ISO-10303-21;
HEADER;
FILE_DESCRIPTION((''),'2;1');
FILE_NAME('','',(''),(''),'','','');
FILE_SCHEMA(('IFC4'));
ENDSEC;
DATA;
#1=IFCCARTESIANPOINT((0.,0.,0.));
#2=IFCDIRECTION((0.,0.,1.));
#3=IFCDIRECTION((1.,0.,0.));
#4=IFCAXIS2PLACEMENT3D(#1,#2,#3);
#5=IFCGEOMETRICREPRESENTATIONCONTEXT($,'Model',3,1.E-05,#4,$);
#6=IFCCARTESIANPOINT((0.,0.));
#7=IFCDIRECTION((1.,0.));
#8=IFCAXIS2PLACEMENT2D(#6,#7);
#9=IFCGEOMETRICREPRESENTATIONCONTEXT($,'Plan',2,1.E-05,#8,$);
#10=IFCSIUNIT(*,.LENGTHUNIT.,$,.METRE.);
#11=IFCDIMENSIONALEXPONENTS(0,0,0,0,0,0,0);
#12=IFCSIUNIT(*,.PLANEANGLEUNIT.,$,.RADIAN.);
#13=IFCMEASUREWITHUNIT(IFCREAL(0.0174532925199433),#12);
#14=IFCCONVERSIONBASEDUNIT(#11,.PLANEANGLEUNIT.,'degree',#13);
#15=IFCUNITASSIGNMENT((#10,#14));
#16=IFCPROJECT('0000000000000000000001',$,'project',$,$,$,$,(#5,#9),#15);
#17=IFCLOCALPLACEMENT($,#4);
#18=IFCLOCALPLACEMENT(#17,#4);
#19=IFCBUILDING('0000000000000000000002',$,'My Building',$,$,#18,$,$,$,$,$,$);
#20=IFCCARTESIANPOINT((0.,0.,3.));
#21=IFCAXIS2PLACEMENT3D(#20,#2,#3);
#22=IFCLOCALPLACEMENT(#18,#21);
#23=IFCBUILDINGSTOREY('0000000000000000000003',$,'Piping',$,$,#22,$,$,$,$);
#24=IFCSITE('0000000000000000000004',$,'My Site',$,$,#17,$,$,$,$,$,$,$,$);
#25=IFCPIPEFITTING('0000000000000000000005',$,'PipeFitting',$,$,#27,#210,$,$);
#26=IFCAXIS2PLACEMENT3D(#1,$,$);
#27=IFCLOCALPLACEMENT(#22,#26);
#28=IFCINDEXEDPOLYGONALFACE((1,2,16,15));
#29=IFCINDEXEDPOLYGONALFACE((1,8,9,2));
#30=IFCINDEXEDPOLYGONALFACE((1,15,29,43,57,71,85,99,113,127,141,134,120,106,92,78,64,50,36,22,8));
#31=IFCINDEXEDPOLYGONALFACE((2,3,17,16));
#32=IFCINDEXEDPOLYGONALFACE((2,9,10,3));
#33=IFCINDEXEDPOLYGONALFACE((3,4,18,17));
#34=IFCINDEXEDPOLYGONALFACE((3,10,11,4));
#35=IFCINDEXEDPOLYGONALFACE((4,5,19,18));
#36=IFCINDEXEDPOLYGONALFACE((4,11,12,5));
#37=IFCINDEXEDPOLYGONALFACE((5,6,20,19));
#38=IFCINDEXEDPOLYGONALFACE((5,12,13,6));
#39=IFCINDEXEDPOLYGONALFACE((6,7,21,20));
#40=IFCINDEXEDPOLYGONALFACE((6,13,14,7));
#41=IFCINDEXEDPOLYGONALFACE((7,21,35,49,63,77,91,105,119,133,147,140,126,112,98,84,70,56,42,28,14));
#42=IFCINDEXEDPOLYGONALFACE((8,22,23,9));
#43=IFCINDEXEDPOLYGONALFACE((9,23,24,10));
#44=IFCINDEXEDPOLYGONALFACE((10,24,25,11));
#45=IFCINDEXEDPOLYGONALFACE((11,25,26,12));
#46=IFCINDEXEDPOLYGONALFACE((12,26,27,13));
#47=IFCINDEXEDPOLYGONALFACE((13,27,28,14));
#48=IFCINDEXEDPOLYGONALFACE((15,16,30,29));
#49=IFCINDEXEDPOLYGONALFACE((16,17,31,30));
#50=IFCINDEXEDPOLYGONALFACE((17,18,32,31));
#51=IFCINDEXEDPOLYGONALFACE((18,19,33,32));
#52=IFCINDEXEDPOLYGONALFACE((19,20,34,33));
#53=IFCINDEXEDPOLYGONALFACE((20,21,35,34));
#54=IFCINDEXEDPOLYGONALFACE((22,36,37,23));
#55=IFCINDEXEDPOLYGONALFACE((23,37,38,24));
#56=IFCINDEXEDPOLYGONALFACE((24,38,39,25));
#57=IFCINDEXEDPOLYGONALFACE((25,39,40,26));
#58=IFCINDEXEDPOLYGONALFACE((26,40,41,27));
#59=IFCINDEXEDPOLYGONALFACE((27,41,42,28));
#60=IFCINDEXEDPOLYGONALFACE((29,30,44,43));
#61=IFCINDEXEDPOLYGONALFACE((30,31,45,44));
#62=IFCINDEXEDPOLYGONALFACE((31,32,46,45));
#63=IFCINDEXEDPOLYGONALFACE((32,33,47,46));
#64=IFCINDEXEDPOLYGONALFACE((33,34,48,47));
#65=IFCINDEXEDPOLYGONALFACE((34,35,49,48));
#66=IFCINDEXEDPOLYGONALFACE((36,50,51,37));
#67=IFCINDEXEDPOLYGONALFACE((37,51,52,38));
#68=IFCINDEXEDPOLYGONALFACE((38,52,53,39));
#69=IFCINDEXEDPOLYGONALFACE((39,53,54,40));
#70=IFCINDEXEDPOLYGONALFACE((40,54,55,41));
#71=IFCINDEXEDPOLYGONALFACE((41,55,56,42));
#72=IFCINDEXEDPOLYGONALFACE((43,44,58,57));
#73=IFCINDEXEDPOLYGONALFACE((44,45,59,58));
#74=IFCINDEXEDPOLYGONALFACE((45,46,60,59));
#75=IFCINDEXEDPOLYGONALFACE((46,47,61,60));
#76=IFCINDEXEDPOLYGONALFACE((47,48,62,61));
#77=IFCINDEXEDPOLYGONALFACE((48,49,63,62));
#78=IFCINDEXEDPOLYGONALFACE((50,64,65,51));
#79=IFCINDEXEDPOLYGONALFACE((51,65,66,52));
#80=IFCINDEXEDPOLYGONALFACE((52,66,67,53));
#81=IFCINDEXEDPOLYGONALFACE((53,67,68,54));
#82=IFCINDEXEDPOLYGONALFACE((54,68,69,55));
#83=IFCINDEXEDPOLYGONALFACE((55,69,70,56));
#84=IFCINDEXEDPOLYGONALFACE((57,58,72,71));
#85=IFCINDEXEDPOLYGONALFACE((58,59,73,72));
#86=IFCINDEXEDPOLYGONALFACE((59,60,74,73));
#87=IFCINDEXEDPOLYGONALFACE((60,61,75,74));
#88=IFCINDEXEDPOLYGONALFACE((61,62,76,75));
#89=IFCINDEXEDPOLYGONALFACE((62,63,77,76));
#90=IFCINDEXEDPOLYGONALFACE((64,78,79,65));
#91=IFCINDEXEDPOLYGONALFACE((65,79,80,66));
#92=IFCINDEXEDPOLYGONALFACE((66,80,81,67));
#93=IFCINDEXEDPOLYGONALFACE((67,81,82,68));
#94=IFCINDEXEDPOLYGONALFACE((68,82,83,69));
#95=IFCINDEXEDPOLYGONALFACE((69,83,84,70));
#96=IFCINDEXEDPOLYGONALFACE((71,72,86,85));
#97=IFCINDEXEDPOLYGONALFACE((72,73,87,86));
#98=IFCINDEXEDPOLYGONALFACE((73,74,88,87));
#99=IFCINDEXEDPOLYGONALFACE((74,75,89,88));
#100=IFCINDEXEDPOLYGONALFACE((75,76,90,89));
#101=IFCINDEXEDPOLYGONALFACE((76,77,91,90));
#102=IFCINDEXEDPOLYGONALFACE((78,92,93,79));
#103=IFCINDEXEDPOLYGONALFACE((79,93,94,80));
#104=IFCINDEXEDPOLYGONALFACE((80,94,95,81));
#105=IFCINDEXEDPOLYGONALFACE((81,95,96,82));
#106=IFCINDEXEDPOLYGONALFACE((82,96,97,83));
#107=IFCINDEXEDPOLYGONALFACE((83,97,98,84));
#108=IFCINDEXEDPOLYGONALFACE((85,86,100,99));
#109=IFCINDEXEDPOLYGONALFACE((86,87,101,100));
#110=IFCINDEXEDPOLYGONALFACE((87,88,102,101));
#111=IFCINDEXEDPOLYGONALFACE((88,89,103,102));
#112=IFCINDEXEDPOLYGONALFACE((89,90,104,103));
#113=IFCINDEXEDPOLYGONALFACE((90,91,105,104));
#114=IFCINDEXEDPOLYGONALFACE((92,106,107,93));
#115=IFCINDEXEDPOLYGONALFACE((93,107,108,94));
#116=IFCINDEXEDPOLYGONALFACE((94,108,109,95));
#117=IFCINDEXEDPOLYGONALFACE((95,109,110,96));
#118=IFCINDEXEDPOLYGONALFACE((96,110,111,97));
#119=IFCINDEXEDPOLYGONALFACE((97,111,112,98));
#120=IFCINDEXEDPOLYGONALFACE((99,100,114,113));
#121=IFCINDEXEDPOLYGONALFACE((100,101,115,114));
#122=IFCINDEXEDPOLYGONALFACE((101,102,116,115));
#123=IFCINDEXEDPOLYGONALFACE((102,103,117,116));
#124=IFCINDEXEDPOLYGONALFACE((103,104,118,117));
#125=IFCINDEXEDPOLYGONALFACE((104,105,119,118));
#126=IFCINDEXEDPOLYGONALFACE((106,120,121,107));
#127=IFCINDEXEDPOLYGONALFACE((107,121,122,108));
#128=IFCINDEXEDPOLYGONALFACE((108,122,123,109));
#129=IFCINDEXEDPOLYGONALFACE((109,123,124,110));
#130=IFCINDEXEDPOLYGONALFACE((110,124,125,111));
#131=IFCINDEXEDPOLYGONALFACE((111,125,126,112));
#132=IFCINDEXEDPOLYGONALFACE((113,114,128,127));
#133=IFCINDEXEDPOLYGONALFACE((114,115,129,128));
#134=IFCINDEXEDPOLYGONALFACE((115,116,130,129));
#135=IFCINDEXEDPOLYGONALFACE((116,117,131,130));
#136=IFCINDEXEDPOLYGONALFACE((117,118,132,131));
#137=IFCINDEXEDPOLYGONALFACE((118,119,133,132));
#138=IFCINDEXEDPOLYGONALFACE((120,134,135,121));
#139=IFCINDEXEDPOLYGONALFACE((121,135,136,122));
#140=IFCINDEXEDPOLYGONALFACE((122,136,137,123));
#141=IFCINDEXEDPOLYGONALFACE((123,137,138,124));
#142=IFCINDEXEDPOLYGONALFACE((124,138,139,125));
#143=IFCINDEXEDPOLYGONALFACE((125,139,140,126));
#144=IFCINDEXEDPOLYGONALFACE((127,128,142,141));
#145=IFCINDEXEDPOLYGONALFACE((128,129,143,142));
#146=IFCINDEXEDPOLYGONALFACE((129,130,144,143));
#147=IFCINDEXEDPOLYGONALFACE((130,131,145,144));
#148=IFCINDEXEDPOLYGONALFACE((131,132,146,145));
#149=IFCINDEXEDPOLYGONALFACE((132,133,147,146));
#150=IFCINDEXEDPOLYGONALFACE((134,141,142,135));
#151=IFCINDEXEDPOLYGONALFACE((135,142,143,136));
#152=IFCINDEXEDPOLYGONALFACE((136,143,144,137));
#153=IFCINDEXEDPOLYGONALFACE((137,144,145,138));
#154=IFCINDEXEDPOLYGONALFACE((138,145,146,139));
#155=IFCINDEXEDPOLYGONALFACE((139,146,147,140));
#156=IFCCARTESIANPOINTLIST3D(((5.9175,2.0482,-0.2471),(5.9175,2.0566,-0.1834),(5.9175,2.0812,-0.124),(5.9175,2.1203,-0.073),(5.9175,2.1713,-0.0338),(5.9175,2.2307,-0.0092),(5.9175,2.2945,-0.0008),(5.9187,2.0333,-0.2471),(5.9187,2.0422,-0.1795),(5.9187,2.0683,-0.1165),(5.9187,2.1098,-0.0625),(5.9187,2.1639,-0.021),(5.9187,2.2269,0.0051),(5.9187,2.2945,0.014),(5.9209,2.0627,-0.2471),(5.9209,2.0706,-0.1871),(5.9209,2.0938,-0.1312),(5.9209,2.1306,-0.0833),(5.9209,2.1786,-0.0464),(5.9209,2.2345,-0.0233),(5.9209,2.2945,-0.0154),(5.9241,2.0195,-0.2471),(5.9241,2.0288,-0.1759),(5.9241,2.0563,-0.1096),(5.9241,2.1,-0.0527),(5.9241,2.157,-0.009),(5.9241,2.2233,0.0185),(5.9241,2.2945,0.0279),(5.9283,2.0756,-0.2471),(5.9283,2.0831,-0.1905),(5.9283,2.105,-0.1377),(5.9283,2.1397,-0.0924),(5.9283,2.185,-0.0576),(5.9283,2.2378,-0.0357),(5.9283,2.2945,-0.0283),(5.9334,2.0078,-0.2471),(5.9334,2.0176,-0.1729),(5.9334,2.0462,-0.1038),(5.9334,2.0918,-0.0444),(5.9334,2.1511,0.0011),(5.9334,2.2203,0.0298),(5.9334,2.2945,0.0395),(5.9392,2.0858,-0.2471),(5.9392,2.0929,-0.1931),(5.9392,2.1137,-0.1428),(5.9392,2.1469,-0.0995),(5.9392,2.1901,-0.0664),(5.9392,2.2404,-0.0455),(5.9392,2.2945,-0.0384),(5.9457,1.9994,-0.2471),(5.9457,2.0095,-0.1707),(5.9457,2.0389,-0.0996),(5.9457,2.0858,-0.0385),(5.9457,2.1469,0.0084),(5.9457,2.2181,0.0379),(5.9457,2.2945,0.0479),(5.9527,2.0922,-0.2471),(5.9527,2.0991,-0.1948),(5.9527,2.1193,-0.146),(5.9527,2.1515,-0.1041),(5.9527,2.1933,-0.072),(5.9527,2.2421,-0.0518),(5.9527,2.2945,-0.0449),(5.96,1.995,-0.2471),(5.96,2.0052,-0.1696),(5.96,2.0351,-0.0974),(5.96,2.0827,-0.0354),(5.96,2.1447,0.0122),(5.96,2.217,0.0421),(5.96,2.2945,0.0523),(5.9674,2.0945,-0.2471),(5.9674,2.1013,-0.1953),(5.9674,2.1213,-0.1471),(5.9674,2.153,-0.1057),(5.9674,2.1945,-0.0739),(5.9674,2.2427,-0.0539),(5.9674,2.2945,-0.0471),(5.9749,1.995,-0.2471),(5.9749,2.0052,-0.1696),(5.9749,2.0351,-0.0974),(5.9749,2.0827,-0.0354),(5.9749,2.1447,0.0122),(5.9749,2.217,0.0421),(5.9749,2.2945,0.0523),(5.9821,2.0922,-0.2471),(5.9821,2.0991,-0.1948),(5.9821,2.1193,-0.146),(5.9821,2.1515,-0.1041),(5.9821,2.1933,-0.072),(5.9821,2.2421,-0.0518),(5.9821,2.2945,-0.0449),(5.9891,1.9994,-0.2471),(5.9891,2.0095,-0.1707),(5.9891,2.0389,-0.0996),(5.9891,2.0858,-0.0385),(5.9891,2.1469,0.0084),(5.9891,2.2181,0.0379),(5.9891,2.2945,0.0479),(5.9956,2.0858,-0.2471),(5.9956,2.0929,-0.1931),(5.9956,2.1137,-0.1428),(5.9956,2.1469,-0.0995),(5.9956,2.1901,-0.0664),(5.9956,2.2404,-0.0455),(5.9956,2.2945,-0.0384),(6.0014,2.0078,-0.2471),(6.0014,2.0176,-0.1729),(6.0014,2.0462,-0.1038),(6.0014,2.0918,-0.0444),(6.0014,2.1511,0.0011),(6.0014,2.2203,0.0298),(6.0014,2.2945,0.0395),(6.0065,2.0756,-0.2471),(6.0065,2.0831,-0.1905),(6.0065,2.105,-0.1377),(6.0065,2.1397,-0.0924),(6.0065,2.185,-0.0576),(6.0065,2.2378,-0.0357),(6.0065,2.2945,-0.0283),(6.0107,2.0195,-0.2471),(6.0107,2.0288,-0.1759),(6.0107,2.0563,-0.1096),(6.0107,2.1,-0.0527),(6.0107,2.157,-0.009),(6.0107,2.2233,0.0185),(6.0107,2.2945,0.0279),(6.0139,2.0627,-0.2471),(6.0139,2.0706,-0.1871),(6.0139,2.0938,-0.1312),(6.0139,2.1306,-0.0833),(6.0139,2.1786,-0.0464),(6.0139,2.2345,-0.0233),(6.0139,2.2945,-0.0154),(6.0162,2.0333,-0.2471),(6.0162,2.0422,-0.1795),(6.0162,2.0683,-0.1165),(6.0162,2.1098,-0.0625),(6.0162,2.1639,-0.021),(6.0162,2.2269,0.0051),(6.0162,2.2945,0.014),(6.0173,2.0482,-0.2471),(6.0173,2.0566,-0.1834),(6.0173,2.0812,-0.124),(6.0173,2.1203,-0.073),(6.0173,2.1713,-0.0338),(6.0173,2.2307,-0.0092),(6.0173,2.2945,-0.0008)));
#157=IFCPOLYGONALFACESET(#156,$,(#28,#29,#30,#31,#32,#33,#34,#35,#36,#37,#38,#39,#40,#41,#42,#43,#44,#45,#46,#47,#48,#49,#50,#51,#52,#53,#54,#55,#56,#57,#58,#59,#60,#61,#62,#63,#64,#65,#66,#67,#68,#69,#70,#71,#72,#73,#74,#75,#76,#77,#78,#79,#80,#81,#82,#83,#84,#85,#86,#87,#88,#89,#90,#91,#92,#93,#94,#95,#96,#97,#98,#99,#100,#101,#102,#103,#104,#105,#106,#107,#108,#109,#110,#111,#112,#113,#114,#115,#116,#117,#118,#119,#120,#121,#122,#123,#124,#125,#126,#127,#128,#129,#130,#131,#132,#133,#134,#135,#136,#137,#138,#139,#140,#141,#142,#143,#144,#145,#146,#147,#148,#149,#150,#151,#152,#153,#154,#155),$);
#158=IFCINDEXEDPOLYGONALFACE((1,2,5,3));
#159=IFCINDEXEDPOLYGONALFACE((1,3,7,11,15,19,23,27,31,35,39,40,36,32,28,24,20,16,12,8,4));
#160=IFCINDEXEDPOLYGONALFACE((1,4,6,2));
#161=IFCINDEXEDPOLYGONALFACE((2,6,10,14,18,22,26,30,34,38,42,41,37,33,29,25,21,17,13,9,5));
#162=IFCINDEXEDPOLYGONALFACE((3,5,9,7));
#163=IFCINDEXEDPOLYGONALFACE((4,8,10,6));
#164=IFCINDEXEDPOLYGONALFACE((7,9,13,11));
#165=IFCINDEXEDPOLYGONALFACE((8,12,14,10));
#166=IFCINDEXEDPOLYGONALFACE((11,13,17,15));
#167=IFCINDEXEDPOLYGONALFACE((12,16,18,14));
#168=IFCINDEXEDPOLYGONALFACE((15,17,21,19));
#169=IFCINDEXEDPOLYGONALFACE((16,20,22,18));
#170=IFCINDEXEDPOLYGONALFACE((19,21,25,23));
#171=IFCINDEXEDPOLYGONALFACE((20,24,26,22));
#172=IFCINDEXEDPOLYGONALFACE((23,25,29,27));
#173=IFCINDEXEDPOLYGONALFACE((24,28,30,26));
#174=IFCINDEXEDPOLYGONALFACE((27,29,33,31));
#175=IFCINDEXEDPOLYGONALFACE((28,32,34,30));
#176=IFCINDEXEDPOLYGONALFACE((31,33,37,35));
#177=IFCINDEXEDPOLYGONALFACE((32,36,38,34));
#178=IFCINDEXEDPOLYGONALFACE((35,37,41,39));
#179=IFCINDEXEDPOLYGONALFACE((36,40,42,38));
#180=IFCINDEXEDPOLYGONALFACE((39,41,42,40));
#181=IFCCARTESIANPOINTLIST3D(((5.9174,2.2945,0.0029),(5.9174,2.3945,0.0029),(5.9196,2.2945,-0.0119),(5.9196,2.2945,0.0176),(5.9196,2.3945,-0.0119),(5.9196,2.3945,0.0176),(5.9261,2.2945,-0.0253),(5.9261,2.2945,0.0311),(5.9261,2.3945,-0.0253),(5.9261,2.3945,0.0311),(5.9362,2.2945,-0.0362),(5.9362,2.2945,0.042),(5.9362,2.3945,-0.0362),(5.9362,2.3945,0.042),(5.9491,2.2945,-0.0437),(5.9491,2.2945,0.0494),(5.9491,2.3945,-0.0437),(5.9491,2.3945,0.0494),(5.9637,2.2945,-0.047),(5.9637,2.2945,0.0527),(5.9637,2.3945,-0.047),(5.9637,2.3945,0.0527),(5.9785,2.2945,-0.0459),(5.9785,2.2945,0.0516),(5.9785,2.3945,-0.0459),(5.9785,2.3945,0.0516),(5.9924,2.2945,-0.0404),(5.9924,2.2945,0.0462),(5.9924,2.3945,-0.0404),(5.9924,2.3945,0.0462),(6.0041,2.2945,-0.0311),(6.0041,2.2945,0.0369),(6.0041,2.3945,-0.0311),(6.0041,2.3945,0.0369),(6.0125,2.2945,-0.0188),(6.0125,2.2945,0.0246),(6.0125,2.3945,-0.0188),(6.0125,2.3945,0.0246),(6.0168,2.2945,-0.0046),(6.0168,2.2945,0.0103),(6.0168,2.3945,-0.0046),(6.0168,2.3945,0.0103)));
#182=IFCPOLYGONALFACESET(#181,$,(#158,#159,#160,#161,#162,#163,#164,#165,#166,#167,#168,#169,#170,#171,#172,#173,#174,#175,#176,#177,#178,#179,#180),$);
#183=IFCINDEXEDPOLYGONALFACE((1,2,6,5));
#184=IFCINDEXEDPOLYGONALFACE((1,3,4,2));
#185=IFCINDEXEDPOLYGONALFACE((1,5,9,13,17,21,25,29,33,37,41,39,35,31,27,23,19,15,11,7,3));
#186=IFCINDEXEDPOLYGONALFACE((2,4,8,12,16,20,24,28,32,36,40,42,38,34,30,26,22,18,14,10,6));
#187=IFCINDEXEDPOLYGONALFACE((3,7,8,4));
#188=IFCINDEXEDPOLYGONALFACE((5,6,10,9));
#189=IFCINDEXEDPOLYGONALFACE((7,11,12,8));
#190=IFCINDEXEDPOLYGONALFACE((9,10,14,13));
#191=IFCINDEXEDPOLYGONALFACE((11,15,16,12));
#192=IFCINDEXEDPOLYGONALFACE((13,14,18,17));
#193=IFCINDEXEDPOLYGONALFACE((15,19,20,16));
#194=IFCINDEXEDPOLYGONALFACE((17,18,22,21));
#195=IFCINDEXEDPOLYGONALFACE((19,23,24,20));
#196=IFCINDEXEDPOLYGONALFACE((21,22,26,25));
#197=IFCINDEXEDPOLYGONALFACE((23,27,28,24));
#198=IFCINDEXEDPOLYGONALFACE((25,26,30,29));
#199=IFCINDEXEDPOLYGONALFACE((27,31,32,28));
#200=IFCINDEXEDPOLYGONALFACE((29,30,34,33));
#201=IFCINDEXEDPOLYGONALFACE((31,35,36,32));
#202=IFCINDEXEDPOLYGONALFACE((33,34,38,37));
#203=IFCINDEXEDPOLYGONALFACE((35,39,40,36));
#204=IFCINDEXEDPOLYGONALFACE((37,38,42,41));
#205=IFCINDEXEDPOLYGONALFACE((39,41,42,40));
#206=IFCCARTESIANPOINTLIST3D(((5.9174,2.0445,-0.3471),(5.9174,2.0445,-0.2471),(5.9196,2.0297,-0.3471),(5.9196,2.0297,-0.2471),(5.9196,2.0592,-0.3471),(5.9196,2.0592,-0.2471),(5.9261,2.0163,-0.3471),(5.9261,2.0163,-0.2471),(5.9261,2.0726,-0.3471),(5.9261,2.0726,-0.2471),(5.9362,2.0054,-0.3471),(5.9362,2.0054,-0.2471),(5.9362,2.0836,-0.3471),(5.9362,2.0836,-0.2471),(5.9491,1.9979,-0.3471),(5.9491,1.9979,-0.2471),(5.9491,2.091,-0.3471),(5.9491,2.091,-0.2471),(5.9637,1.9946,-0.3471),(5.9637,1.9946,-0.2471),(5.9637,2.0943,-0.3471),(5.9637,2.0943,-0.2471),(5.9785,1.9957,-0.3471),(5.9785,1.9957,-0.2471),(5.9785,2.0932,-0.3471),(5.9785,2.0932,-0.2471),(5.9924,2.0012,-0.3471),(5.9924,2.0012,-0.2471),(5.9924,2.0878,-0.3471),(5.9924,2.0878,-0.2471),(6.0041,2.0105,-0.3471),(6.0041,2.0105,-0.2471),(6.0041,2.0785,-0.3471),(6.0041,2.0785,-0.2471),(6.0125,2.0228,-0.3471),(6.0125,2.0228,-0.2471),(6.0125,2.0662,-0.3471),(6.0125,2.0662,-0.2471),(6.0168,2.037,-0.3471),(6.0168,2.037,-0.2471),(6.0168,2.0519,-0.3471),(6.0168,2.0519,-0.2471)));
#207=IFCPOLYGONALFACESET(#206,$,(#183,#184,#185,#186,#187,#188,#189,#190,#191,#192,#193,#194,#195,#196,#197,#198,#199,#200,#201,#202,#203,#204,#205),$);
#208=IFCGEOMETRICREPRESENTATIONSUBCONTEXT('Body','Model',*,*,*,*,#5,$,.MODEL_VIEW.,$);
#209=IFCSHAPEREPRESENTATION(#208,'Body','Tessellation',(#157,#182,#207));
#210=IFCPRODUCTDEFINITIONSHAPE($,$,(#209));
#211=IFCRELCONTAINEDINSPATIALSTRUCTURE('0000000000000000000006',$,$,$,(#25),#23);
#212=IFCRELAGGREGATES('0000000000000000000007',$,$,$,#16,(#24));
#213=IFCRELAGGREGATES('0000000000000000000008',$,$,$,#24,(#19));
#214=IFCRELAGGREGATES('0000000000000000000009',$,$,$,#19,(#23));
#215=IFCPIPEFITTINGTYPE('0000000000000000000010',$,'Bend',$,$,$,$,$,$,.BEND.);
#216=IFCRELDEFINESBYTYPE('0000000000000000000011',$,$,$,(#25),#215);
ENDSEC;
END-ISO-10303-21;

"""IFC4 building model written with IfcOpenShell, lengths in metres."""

from ifc_helpers import new_model, entity, si_unit, converted_unit, frame, origin_with_axes, origin_2d_with_axis, place, context, subcontext, project, spatial, circle, extrude, source, transform, mapped, type_object, type_shapes, element, save


model = new_model("IFC4")

# Units and contexts
model_context = context("Model", 3, precision=1e-05, world=origin_with_axes())
plan_context = context("Plan", 2, precision=1e-05, world=origin_2d_with_axis())
body_context = subcontext(model_context, "Body", "Model", "MODEL_VIEW")
ifc_project = project(units=[si_unit("LENGTHUNIT", "METRE"), converted_unit("PLANEANGLEUNIT", "degree", entity("IfcReal", 0.0174532925199433), si_unit("PLANEANGLEUNIT", "RADIAN"), dimensions=[0, 0, 0, 0, 0, 0, 0])], contexts=[model_context, plan_context])

# Site, building, storey
site_placement = place(None, origin_with_axes())
site = spatial("IfcSite", under=ifc_project, at=site_placement, Name="My Site")
building_placement = place(site_placement, origin_with_axes())
building = spatial("IfcBuilding", under=site, at=building_placement, Name="My Building")
storey_placement = place(building_placement, frame((0.0, 0.0, 3.0), z_axis=(0.0, 0.0, 1.0), x_axis=(1.0, 0.0, 0.0)))
storey = spatial("IfcBuildingStorey", under=building, at=storey_placement, Name="Piping")

# Pipe fitting
pipe_fitting_type_1 = type_object("IfcPipeFittingType", Name="Bend", PredefinedType="BEND")
shared_shape = source(origin_with_axes(), body_context, "Body", "SolidModel", [
    entity("IfcSweptDiskSolid", entity("IfcIndexedPolyCurve", entity("IfcCartesianPointList3D", [[0.0, 0.0, -0.1], [0.0, -0.0732, -0.2768], [0.0, -0.25, -0.35]]), [entity("IfcArcIndex", [1, 2, 3])]), 0.05),
    extrude(circle(Radius=0.05), origin_with_axes(), (0.0, 0.0, -1.0), 0.1),
    extrude(circle(Radius=0.05), frame((0.0, -0.25, -0.35), z_axis=(0.0, -1.0, 0.0), x_axis=(1.0, 0.0, 0.0)), (0.0, 0.0, 1.0), 0.1),
])
type_shapes(pipe_fitting_type_1, [shared_shape])
for number, where, z_axis, x_axis, name in (
    (1, (5.9674, 2.3945, 0.0029), (0.0, 1.0, 0.0), (-1.0, 0.0, 0.0), "PipeFitting"),
):
    element("IfcPipeFitting", number, at=place(storey_placement, frame(where, z_axis=z_axis, x_axis=x_axis)), inside=storey, type_object=pipe_fitting_type_1, Name=name, context=body_context, shape_type="MappedRepresentation", body=[
        mapped(shared_shape, transform((0.0, 0.0, 0.0), x_axis=(1.0, 0.0, 0.0), y_axis=(0.0, 1.0, 0.0), z_axis=(0.0, 0.0, 1.0), scale=1.0)),
    ])

save(model, "model.ifc")
